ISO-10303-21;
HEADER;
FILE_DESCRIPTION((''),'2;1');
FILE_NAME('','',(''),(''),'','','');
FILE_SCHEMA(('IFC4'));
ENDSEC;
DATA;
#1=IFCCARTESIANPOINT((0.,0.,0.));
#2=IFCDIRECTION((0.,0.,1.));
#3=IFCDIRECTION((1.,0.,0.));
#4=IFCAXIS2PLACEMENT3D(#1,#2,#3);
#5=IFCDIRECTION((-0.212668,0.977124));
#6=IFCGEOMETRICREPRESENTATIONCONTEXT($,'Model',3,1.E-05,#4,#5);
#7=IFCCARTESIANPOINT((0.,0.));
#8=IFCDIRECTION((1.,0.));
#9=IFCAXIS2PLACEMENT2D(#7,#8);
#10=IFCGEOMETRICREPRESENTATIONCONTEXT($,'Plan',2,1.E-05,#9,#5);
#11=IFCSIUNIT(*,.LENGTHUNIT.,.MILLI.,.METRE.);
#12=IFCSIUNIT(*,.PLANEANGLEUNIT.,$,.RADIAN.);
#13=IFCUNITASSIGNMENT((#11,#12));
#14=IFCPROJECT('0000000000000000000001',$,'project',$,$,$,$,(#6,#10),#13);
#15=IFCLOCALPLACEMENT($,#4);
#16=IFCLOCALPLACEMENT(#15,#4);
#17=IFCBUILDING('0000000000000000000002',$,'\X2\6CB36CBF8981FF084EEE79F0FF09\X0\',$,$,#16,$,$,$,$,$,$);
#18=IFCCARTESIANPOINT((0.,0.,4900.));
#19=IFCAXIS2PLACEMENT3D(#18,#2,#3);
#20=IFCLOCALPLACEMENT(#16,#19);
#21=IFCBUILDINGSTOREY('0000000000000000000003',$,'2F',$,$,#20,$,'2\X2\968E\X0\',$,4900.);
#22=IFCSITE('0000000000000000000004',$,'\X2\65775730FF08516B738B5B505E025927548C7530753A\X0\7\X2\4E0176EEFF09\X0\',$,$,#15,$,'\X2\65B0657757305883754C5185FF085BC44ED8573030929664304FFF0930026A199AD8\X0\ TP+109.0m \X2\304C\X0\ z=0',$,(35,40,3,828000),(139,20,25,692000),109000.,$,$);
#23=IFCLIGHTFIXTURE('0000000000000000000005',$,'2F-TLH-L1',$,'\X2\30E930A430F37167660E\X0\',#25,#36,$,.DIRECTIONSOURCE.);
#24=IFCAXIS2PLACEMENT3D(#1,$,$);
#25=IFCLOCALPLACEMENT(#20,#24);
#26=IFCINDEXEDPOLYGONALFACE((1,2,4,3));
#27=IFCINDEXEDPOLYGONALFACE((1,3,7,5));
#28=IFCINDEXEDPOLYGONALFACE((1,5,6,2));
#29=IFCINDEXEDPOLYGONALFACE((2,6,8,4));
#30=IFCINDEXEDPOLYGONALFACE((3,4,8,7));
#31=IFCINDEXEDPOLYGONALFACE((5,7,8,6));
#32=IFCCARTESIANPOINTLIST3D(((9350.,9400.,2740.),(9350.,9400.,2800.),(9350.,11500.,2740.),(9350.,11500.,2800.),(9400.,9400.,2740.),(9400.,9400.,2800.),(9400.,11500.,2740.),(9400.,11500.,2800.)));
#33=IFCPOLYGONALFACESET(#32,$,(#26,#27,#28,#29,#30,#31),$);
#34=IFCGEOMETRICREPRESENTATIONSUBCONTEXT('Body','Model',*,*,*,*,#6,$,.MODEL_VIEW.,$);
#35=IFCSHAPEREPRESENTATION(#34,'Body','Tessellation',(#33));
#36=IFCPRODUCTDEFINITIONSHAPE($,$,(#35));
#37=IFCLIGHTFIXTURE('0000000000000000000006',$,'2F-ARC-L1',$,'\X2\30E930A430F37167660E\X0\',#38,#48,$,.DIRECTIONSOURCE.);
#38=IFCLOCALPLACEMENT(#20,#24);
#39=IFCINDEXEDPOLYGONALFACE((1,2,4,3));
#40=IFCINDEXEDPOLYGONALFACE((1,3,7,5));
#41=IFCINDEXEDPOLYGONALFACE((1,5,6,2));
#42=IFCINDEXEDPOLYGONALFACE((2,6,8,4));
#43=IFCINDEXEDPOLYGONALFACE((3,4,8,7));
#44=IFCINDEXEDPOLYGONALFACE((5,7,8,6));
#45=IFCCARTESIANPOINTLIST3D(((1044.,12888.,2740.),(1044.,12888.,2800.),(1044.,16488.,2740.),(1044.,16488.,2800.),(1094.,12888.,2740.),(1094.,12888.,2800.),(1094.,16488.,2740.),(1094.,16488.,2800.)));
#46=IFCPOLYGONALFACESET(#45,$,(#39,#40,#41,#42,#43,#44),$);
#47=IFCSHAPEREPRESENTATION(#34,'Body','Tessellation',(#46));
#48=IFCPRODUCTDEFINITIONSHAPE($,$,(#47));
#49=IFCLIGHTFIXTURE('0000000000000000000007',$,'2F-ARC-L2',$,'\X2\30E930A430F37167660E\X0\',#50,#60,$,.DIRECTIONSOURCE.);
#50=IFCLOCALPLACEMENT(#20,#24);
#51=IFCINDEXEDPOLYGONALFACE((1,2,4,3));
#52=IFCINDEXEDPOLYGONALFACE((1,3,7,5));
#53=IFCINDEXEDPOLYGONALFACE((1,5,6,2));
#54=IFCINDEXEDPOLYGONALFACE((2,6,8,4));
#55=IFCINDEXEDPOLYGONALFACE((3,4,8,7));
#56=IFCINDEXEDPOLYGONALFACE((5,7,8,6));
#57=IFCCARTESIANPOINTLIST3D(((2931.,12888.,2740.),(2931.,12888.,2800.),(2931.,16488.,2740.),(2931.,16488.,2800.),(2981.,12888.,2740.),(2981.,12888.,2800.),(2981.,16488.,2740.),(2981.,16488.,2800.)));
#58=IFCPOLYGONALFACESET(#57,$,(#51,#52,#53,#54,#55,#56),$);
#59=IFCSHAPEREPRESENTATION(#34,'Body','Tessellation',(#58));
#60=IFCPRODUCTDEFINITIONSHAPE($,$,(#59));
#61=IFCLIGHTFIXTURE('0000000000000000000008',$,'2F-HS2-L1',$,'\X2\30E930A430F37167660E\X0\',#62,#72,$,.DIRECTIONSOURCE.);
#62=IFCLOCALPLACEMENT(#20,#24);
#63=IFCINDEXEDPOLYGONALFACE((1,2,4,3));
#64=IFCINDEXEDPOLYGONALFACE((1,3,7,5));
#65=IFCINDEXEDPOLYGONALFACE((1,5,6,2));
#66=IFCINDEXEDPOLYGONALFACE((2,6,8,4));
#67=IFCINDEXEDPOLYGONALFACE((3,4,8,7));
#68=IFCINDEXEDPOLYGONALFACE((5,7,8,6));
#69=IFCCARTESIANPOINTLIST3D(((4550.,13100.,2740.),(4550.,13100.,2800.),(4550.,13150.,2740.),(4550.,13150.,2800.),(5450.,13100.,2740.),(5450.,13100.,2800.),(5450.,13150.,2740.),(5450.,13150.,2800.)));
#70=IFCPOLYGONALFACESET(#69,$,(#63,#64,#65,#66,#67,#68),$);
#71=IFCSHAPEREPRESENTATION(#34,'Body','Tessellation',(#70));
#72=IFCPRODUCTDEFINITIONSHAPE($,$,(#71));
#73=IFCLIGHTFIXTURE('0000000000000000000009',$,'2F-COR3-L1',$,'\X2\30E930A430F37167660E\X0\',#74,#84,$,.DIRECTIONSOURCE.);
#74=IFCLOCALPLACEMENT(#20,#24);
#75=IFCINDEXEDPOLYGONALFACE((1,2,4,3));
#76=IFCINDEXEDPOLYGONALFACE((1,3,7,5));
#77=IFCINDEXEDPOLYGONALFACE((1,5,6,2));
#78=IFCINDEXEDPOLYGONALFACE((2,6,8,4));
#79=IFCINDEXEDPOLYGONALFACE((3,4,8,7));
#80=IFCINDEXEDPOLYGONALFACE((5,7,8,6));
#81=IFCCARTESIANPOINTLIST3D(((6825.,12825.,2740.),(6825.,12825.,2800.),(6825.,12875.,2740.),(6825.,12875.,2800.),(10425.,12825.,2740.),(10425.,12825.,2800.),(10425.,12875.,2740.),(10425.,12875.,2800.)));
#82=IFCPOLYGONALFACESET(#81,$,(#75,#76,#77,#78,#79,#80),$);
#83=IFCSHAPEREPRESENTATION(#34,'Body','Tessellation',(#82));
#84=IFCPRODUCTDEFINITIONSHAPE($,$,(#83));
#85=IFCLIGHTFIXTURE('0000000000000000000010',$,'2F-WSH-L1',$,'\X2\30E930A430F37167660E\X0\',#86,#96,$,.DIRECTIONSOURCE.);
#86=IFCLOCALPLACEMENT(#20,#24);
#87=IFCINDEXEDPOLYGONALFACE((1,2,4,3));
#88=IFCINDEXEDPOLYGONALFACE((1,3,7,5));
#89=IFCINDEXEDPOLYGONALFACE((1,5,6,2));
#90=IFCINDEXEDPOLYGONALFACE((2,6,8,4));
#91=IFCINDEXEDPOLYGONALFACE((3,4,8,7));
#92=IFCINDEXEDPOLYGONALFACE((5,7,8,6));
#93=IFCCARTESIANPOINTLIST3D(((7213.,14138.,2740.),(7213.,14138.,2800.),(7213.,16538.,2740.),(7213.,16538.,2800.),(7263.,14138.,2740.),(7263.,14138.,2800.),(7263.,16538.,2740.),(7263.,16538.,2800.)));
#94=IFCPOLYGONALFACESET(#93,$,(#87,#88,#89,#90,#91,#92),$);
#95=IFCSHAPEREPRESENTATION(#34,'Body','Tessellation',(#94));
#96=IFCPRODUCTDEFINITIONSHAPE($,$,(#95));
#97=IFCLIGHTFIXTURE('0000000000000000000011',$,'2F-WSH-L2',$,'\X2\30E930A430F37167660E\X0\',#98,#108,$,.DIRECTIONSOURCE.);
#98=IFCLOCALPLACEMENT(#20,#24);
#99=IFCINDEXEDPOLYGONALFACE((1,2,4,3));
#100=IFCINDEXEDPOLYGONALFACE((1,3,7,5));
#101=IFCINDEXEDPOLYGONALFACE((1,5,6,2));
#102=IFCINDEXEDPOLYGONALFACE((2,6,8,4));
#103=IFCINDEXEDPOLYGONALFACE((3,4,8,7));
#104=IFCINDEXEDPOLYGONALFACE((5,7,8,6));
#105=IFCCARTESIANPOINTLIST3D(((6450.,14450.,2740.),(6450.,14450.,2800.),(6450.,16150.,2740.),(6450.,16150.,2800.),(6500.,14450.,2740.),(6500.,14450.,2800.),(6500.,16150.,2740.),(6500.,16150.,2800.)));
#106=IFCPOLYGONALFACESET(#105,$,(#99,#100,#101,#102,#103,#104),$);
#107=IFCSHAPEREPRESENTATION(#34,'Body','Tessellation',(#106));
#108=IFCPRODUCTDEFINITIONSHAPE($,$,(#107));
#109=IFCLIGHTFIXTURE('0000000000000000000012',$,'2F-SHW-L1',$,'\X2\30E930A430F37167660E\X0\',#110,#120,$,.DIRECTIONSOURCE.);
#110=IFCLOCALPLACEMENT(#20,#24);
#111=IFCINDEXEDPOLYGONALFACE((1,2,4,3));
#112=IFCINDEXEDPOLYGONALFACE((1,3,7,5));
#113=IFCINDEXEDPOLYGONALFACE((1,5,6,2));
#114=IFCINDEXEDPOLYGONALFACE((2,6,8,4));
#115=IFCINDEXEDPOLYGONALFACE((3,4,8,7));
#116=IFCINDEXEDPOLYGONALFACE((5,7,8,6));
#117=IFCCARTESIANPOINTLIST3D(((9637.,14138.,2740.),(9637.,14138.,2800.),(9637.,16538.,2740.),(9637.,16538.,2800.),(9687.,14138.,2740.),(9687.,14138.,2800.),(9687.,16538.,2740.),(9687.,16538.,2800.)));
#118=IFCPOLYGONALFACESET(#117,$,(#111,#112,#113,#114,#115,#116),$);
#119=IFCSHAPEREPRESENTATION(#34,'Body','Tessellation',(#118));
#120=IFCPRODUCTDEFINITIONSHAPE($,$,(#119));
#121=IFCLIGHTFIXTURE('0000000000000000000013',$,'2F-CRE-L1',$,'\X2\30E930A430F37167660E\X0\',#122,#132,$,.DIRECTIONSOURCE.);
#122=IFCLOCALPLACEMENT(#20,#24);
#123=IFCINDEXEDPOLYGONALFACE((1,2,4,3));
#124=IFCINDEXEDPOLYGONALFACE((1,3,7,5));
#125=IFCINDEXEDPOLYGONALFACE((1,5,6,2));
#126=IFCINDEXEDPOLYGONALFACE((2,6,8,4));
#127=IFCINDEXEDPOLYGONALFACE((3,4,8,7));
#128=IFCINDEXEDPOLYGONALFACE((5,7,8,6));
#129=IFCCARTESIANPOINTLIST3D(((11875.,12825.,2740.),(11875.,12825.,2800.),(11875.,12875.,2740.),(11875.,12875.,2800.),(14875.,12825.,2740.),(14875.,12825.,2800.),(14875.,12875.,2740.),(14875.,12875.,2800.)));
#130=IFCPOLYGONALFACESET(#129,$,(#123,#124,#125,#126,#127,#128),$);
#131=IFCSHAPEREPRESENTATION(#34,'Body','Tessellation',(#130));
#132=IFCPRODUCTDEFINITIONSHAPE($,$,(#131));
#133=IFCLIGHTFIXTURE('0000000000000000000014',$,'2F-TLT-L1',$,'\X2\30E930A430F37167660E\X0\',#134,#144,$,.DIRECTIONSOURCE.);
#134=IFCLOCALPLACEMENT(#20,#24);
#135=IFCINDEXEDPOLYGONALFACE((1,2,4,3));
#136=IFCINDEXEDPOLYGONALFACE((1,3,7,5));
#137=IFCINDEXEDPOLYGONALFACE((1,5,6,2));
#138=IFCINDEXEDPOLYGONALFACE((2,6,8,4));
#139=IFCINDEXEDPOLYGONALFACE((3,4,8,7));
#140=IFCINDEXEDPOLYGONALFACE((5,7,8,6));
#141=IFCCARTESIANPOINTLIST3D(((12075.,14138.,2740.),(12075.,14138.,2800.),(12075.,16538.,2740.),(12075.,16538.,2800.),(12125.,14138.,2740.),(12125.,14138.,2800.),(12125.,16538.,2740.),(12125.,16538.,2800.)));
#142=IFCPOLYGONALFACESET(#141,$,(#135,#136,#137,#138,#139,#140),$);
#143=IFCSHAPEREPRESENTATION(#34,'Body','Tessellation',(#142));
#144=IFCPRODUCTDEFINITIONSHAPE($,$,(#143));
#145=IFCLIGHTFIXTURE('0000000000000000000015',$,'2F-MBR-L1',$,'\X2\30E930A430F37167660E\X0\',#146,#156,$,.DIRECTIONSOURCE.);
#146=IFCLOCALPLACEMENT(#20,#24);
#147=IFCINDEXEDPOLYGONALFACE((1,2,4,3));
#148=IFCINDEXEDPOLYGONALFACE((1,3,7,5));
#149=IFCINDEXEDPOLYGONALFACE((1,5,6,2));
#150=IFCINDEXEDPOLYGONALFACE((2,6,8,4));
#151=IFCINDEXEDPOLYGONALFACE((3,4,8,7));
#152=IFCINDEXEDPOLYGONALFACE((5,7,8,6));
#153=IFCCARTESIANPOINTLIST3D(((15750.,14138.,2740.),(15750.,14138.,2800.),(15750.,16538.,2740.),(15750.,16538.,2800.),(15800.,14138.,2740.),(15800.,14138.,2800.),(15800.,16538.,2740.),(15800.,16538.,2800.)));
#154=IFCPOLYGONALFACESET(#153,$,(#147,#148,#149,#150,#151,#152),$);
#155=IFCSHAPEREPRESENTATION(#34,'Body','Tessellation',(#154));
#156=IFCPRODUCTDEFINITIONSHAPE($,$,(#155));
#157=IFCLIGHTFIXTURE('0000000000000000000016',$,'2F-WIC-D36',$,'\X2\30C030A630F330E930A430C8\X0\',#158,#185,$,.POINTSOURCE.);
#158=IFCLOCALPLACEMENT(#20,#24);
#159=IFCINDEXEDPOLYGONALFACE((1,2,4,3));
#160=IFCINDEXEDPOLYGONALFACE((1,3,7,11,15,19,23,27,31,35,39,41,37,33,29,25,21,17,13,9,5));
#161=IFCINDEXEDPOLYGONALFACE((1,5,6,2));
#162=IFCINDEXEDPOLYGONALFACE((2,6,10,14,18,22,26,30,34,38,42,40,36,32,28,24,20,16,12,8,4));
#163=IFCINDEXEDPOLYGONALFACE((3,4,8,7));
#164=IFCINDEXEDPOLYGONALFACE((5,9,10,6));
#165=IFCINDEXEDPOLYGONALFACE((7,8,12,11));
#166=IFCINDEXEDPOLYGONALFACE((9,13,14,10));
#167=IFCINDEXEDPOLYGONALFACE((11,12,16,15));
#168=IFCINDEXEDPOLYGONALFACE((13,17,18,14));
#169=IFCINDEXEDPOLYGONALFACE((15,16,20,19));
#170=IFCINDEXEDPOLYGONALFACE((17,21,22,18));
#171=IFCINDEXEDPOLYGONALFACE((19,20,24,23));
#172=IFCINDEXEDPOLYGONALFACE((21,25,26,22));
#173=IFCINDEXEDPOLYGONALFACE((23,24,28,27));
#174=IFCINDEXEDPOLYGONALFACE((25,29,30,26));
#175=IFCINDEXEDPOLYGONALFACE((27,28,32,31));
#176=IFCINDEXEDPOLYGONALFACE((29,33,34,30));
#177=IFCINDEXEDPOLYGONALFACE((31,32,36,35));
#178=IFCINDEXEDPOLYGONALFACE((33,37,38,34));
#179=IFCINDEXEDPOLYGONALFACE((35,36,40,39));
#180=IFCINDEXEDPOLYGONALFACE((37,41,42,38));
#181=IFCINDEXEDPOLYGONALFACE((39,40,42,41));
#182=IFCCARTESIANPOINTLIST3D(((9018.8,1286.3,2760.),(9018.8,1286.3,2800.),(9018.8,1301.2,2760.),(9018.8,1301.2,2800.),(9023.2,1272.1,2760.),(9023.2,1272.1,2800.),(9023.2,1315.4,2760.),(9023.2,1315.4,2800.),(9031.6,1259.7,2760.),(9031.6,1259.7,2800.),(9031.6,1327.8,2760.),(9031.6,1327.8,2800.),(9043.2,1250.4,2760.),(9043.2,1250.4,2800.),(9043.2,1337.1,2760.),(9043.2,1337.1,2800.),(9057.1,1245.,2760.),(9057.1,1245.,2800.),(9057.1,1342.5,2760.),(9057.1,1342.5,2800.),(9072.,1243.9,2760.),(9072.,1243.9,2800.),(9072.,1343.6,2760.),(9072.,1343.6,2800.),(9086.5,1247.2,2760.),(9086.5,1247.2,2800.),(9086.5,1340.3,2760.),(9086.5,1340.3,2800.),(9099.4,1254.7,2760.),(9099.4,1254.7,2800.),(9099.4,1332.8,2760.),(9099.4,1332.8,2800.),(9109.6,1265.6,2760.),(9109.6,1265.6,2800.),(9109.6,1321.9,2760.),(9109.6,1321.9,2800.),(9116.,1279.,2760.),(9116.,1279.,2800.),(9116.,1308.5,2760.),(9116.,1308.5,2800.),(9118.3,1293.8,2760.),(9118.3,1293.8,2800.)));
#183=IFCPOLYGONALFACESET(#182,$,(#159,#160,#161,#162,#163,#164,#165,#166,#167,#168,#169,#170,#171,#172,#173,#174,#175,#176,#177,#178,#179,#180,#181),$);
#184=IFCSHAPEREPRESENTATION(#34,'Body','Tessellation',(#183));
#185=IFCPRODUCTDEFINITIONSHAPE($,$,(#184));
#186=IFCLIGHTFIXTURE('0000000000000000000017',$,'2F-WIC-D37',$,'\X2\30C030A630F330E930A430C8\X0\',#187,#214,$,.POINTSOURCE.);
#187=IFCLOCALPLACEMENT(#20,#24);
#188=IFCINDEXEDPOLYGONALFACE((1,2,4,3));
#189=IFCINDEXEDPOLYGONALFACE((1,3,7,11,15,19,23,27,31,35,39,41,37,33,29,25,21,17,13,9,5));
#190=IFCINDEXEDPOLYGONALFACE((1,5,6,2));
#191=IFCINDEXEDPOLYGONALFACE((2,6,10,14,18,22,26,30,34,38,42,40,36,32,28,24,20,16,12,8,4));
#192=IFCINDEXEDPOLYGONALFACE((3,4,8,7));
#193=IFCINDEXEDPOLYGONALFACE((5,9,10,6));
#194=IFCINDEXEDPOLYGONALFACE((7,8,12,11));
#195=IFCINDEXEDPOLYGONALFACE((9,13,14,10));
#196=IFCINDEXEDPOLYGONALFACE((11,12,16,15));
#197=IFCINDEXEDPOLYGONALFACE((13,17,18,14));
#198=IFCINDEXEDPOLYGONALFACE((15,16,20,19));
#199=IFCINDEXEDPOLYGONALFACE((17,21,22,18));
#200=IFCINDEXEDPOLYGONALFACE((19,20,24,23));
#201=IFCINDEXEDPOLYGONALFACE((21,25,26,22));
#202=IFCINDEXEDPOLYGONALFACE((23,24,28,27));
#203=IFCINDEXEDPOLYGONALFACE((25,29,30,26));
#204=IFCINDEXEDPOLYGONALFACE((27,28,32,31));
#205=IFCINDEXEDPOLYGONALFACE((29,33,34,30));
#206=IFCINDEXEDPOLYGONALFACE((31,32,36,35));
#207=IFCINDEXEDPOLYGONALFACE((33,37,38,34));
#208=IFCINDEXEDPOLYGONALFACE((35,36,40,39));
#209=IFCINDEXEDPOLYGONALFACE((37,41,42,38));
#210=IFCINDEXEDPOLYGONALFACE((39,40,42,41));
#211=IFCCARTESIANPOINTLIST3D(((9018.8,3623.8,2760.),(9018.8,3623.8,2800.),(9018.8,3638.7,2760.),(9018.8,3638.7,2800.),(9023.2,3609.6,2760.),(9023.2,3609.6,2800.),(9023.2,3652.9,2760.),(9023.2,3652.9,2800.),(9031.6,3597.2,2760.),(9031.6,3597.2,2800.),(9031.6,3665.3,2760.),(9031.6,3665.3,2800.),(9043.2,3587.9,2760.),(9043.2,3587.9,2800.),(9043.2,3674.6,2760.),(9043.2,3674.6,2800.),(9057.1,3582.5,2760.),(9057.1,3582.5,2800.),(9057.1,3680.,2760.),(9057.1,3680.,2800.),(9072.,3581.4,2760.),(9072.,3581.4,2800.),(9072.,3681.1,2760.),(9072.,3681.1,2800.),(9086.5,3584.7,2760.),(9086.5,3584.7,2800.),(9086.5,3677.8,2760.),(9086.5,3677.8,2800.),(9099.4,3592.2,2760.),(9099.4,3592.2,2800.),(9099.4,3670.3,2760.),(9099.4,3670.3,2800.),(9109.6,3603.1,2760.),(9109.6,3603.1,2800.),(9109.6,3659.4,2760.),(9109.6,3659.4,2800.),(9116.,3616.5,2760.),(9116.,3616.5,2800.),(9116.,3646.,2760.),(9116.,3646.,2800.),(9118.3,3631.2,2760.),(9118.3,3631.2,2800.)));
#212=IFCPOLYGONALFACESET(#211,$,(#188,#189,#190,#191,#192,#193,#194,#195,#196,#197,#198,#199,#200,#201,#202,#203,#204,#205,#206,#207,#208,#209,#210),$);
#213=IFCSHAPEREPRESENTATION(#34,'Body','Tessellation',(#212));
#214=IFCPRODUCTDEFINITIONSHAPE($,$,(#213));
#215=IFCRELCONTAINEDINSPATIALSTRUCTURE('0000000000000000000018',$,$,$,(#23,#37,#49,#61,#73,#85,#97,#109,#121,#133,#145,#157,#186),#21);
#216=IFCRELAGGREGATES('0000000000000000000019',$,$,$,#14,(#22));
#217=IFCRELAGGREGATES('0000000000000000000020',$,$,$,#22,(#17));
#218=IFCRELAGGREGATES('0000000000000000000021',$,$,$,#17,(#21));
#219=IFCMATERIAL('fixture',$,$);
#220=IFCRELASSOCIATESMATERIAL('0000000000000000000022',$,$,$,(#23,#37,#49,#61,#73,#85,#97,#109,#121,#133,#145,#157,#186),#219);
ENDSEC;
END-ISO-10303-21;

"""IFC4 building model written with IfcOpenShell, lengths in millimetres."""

from ifc_helpers import new_model, si_unit, direction, frame, frame_2d, origin_with_axes, origin_2d_with_axis, place, context, subcontext, project, spatial, rectangle, circle, extrude, material, element, save


model = new_model("IFC4")

# Units and contexts
model_context = context("Model", 3, precision=1e-05, world=origin_with_axes(), true_north=direction((-0.212668, 0.977124)))
plan_context = context("Plan", 2, precision=1e-05, world=origin_2d_with_axis(), true_north=direction((-0.212668, 0.977124)))
body_context = subcontext(model_context, "Body", "Model", "MODEL_VIEW")
ifc_project = project(units=[si_unit("LENGTHUNIT", "METRE", prefix="MILLI"), si_unit("PLANEANGLEUNIT", "RADIAN")], contexts=[model_context, plan_context])

# Site, building, storey
site_placement = place(None, origin_with_axes())
site = spatial("IfcSite", under=ifc_project, at=site_placement, Name="敷地（八王子市大和田町7丁目）", LongName="新敷地境界内（寄付地を除く）。標高 TP+109.0m が z=0", RefLatitude=(35, 40, 3, 828000), RefLongitude=(139, 20, 25, 692000), RefElevation=109000.0)
building_placement = place(site_placement, origin_with_axes())
building = spatial("IfcBuilding", under=site, at=building_placement, Name="河沿要（仮称）")
storey_placement = place(building_placement, frame((0.0, 0.0, 4900.0), z_axis=(0.0, 0.0, 1.0), x_axis=(1.0, 0.0, 0.0)))
storey = spatial("IfcBuildingStorey", under=building, at=storey_placement, Name="2F", LongName="2階", Elevation=4900.0)

# Light fixtures
ifc_material = material(Name="fixture")
light_fixture_1_placement = place(storey_placement, origin_with_axes())
element("IfcLightFixture", 1, at=light_fixture_1_placement, inside=storey, material=ifc_material, Name="2F-TLH-L1", ObjectType="ライン照明", PredefinedType="DIRECTIONSOURCE", context=body_context, shape_type="SweptSolid", body=[
    extrude(rectangle(XDim=50.0, YDim=2100.0, at=frame_2d((9375.0, 10450.0))), frame((0.0, 0.0, 2740.0)), (0.0, 0.0, 1.0), 60.0),
])
light_fixture_2_placement = place(storey_placement, origin_with_axes())
element("IfcLightFixture", 2, at=light_fixture_2_placement, inside=storey, material=ifc_material, Name="2F-ARC-L1", ObjectType="ライン照明", PredefinedType="DIRECTIONSOURCE", context=body_context, shape_type="SweptSolid", body=[
    extrude(rectangle(XDim=50.0, YDim=3600.0, at=frame_2d((1069.0, 14688.0))), frame((0.0, 0.0, 2740.0)), (0.0, 0.0, 1.0), 60.0),
])
light_fixture_3_placement = place(storey_placement, origin_with_axes())
element("IfcLightFixture", 3, at=light_fixture_3_placement, inside=storey, material=ifc_material, Name="2F-ARC-L2", ObjectType="ライン照明", PredefinedType="DIRECTIONSOURCE", context=body_context, shape_type="SweptSolid", body=[
    extrude(rectangle(XDim=50.0, YDim=3600.0, at=frame_2d((2956.0, 14688.0))), frame((0.0, 0.0, 2740.0)), (0.0, 0.0, 1.0), 60.0),
])
light_fixture_4_placement = place(storey_placement, origin_with_axes())
element("IfcLightFixture", 4, at=light_fixture_4_placement, inside=storey, material=ifc_material, Name="2F-HS2-L1", ObjectType="ライン照明", PredefinedType="DIRECTIONSOURCE", context=body_context, shape_type="SweptSolid", body=[
    extrude(rectangle(XDim=900.0, YDim=50.0, at=frame_2d((5000.0, 13125.0))), frame((0.0, 0.0, 2740.0)), (0.0, 0.0, 1.0), 60.0),
])
light_fixture_5_placement = place(storey_placement, origin_with_axes())
element("IfcLightFixture", 5, at=light_fixture_5_placement, inside=storey, material=ifc_material, Name="2F-COR3-L1", ObjectType="ライン照明", PredefinedType="DIRECTIONSOURCE", context=body_context, shape_type="SweptSolid", body=[
    extrude(rectangle(XDim=3600.0, YDim=50.0, at=frame_2d((8625.0, 12850.0))), frame((0.0, 0.0, 2740.0)), (0.0, 0.0, 1.0), 60.0),
])
light_fixture_6_placement = place(storey_placement, origin_with_axes())
element("IfcLightFixture", 6, at=light_fixture_6_placement, inside=storey, material=ifc_material, Name="2F-WSH-L1", ObjectType="ライン照明", PredefinedType="DIRECTIONSOURCE", context=body_context, shape_type="SweptSolid", body=[
    extrude(rectangle(XDim=50.0, YDim=2400.0, at=frame_2d((7238.0, 15338.0))), frame((0.0, 0.0, 2740.0)), (0.0, 0.0, 1.0), 60.0),
])
light_fixture_7_placement = place(storey_placement, origin_with_axes())
element("IfcLightFixture", 7, at=light_fixture_7_placement, inside=storey, material=ifc_material, Name="2F-WSH-L2", ObjectType="ライン照明", PredefinedType="DIRECTIONSOURCE", context=body_context, shape_type="SweptSolid", body=[
    extrude(rectangle(XDim=50.0, YDim=1700.0, at=frame_2d((6475.0, 15300.0))), frame((0.0, 0.0, 2740.0)), (0.0, 0.0, 1.0), 60.0),
])
light_fixture_8_placement = place(storey_placement, origin_with_axes())
element("IfcLightFixture", 8, at=light_fixture_8_placement, inside=storey, material=ifc_material, Name="2F-SHW-L1", ObjectType="ライン照明", PredefinedType="DIRECTIONSOURCE", context=body_context, shape_type="SweptSolid", body=[
    extrude(rectangle(XDim=50.0, YDim=2400.0, at=frame_2d((9662.0, 15338.0))), frame((0.0, 0.0, 2740.0)), (0.0, 0.0, 1.0), 60.0),
])
light_fixture_9_placement = place(storey_placement, origin_with_axes())
element("IfcLightFixture", 9, at=light_fixture_9_placement, inside=storey, material=ifc_material, Name="2F-CRE-L1", ObjectType="ライン照明", PredefinedType="DIRECTIONSOURCE", context=body_context, shape_type="SweptSolid", body=[
    extrude(rectangle(XDim=3000.0, YDim=50.0, at=frame_2d((13375.0, 12850.0))), frame((0.0, 0.0, 2740.0)), (0.0, 0.0, 1.0), 60.0),
])
light_fixture_10_placement = place(storey_placement, origin_with_axes())
element("IfcLightFixture", 10, at=light_fixture_10_placement, inside=storey, material=ifc_material, Name="2F-TLT-L1", ObjectType="ライン照明", PredefinedType="DIRECTIONSOURCE", context=body_context, shape_type="SweptSolid", body=[
    extrude(rectangle(XDim=50.0, YDim=2400.0, at=frame_2d((12100.0, 15338.0))), frame((0.0, 0.0, 2740.0)), (0.0, 0.0, 1.0), 60.0),
])
light_fixture_11_placement = place(storey_placement, origin_with_axes())
element("IfcLightFixture", 11, at=light_fixture_11_placement, inside=storey, material=ifc_material, Name="2F-MBR-L1", ObjectType="ライン照明", PredefinedType="DIRECTIONSOURCE", context=body_context, shape_type="SweptSolid", body=[
    extrude(rectangle(XDim=50.0, YDim=2400.0, at=frame_2d((15775.0, 15338.0))), frame((0.0, 0.0, 2740.0)), (0.0, 0.0, 1.0), 60.0),
])
light_fixture_12_placement = place(storey_placement, origin_with_axes())
element("IfcLightFixture", 12, at=light_fixture_12_placement, inside=storey, material=ifc_material, Name="2F-WIC-D36", ObjectType="ダウンライト", PredefinedType="POINTSOURCE", context=body_context, shape_type="SweptSolid", body=[
    extrude(circle(Radius=50.0, at=frame_2d((9068.2, 1293.8))), frame((0.0, 0.0, 2760.0)), (0.0, 0.0, 1.0), 40.0),
])
light_fixture_13_placement = place(storey_placement, origin_with_axes())
element("IfcLightFixture", 13, at=light_fixture_13_placement, inside=storey, material=ifc_material, Name="2F-WIC-D37", ObjectType="ダウンライト", PredefinedType="POINTSOURCE", context=body_context, shape_type="SweptSolid", body=[
    extrude(circle(Radius=50.0, at=frame_2d((9068.2, 3631.2))), frame((0.0, 0.0, 2760.0)), (0.0, 0.0, 1.0), 40.0),
])

save(model, "model.ifc")
